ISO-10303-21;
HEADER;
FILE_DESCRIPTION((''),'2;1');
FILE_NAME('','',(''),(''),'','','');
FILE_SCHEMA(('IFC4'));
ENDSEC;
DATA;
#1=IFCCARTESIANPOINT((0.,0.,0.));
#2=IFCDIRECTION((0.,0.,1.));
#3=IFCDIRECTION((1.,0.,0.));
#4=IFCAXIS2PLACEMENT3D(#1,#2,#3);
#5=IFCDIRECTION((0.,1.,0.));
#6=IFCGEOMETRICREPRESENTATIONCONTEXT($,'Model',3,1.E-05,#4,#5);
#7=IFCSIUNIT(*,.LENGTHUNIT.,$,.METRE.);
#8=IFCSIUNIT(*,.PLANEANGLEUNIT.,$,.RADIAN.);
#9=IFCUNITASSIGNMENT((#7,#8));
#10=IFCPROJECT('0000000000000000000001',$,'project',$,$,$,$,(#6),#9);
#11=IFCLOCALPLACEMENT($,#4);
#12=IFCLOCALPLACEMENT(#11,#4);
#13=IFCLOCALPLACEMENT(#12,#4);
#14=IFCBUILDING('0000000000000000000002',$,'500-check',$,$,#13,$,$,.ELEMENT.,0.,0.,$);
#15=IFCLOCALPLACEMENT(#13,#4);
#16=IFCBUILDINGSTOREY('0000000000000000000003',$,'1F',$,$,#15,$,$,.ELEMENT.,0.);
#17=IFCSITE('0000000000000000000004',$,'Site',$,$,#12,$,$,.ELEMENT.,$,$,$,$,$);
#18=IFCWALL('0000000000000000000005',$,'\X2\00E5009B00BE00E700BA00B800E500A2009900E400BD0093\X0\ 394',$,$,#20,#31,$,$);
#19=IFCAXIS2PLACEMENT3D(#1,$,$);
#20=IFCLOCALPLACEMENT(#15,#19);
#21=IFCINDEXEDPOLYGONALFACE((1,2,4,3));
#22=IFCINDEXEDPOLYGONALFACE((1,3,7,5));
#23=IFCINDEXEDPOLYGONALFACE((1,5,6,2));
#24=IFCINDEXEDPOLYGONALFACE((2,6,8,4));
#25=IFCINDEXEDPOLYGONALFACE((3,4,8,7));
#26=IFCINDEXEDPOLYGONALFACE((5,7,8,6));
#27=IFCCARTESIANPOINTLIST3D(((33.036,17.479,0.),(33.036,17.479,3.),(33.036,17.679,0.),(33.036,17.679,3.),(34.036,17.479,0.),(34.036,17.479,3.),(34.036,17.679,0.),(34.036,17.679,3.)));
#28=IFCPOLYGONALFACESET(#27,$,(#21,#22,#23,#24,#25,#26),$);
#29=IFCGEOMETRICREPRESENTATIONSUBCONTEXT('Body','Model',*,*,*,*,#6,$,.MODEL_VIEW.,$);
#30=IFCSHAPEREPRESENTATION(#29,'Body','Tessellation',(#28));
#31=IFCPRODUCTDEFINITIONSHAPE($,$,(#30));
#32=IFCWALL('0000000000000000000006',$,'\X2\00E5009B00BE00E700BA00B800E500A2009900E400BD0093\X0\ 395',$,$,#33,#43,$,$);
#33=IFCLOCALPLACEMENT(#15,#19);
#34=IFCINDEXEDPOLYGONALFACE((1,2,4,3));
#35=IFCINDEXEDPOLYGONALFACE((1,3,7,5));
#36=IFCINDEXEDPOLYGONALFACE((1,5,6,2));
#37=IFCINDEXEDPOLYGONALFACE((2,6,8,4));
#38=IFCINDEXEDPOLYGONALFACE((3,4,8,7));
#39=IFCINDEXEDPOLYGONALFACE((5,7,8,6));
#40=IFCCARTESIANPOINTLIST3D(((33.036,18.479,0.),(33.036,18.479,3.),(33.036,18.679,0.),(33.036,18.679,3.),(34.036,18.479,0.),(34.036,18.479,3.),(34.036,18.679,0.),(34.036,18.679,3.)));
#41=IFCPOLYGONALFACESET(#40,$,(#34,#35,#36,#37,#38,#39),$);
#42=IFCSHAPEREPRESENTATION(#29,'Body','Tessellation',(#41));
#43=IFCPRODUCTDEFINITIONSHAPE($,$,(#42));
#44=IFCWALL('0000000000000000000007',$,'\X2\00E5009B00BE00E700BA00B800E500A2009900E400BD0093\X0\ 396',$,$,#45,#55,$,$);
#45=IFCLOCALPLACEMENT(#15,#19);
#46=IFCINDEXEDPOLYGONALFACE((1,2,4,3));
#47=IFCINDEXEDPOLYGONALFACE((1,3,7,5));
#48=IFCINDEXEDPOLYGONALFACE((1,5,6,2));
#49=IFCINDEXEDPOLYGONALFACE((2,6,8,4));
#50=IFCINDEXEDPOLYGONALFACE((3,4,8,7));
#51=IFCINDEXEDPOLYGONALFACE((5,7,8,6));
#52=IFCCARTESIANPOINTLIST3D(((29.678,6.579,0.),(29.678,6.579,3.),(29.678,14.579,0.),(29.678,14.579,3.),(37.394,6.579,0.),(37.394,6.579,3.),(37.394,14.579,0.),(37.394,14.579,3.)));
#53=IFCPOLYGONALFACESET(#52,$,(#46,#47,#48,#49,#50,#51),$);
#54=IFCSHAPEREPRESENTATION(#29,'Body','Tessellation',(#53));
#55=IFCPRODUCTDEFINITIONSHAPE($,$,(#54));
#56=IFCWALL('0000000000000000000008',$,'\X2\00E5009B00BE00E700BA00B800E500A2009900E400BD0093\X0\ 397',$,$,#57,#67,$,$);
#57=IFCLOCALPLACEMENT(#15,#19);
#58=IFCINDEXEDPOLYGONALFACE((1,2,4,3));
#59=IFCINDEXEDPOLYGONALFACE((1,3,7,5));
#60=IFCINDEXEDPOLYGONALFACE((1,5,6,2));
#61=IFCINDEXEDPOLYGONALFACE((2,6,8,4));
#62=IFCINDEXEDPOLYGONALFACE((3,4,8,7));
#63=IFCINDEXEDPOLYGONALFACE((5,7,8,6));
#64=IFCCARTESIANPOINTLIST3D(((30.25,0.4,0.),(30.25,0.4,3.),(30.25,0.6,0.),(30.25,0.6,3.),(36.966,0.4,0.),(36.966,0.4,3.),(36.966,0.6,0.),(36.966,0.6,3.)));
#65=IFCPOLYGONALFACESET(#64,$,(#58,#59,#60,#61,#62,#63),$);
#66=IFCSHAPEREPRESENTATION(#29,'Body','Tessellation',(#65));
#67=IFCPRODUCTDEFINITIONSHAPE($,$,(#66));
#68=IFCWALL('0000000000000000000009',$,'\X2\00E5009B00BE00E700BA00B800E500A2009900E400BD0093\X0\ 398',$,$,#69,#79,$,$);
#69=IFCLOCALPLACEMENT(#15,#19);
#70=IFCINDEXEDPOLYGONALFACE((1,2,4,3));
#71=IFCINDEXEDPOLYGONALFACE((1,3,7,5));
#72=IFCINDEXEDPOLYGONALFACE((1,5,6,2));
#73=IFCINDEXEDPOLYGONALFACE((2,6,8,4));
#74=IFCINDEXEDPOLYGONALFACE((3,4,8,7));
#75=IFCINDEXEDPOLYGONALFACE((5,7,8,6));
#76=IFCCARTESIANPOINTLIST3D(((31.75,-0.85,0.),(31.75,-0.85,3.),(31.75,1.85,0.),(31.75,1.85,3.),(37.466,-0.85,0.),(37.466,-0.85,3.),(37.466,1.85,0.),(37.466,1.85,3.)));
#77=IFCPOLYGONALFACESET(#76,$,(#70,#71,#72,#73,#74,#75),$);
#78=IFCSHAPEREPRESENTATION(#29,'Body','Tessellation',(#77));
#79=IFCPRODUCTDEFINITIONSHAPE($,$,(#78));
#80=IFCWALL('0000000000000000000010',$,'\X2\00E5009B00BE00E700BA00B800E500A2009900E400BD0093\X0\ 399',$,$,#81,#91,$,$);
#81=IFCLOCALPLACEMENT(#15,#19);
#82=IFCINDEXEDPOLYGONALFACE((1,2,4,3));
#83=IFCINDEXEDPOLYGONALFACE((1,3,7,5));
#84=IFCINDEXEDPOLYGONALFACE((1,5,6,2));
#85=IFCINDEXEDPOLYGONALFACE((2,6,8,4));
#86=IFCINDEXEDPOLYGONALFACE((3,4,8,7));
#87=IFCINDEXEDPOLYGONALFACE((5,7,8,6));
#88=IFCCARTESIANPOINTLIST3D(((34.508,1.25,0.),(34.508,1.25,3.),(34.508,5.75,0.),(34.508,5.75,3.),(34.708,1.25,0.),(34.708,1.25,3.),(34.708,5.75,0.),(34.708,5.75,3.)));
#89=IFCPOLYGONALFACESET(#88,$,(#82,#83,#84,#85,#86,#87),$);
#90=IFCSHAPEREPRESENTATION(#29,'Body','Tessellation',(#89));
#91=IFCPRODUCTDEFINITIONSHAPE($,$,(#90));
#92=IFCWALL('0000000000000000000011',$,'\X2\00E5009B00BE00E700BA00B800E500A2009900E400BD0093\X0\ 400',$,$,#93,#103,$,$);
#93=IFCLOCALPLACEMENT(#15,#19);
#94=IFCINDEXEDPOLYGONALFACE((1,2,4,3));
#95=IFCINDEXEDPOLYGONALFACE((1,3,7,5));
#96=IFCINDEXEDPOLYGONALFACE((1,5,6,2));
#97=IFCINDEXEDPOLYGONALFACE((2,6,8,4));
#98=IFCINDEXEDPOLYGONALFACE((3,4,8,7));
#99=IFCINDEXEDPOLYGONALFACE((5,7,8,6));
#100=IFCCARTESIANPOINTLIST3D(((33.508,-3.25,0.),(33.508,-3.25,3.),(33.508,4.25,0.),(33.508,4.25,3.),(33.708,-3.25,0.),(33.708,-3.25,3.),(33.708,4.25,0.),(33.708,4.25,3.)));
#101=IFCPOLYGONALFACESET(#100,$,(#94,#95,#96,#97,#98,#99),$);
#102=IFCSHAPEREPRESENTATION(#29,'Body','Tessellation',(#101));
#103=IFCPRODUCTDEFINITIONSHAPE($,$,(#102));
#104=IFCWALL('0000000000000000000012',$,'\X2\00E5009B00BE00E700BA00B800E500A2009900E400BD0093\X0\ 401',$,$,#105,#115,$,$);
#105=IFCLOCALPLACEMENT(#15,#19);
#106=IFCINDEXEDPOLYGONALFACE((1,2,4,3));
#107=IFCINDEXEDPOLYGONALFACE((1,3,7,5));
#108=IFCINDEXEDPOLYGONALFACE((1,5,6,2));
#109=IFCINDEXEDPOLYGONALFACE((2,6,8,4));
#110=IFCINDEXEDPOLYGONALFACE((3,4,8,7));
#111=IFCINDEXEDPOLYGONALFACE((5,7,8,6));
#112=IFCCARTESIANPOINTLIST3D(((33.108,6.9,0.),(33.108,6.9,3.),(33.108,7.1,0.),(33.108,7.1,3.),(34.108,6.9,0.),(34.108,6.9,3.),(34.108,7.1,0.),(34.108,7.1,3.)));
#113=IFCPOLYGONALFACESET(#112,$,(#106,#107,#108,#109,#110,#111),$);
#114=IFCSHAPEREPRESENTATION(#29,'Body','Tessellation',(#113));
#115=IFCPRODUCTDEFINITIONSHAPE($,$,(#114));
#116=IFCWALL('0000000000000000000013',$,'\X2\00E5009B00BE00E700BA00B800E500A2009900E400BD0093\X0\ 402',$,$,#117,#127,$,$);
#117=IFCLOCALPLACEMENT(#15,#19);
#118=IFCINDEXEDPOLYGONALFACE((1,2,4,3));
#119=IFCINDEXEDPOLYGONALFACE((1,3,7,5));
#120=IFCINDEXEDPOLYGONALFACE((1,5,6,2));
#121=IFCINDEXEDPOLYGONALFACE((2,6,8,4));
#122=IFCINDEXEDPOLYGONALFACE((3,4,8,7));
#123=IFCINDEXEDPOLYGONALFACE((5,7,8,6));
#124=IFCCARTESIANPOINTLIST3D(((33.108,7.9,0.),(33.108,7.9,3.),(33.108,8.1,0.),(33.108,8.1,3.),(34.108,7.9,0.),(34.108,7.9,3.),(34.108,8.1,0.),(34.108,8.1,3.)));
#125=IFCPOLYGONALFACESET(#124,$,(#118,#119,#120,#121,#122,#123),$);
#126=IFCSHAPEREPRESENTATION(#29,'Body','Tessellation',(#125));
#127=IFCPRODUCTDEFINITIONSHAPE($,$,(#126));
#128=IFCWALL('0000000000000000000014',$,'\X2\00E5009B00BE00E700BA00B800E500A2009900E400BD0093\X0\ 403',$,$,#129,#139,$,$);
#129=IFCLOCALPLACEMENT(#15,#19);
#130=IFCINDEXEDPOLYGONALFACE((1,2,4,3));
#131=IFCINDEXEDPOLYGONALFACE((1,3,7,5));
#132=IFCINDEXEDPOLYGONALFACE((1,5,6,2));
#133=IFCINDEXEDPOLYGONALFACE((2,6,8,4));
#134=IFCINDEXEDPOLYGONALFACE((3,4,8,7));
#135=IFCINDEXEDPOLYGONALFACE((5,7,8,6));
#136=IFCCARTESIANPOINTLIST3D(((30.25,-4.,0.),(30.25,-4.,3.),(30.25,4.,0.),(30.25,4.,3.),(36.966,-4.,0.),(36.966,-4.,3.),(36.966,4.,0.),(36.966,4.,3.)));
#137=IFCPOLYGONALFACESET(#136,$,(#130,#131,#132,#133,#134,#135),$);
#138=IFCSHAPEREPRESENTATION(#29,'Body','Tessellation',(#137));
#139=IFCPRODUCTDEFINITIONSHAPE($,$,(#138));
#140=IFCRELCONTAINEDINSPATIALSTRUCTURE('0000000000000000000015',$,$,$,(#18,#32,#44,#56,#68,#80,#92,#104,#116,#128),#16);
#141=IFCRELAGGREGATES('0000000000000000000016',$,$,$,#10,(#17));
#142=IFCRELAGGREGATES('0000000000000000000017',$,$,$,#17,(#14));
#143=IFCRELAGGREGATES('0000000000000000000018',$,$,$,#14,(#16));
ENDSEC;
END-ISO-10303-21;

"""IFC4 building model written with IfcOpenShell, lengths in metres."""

from ifc_helpers import new_model, si_unit, direction, frame, frame_2d, origin_with_axes, place, context, subcontext, project, spatial, rectangle, extrude, element, save


model = new_model("IFC4")

# Units and contexts
model_context = context("Model", 3, precision=1e-05, world=origin_with_axes(), true_north=direction((0.0, 1.0, 0.0)))
body_context = subcontext(model_context, "Body", "Model", "MODEL_VIEW")
ifc_project = project(units=[si_unit("LENGTHUNIT", "METRE"), si_unit("PLANEANGLEUNIT", "RADIAN")], contexts=[model_context])

# Site, building, storey
placement = place(None, origin_with_axes())
site_placement = place(placement, origin_with_axes())
site = spatial("IfcSite", under=ifc_project, at=site_placement, Name="Site", CompositionType="ELEMENT")
building_placement = place(site_placement, origin_with_axes())
building = spatial("IfcBuilding", under=site, at=building_placement, Name="500-check", CompositionType="ELEMENT", ElevationOfRefHeight=0.0, ElevationOfTerrain=0.0)
storey_placement = place(building_placement, origin_with_axes())
storey = spatial("IfcBuildingStorey", under=building, at=storey_placement, Name="1F", CompositionType="ELEMENT", Elevation=0.0)

# Walls
for number, where, z_axis, x_axis, name in (
    (1, (33.536, 17.579, 0.0), (0.0, 0.0, 1.0), (1.0, 0.0, 0.0), "å\u009b¾çº¸å¢\u0099ä½\u0093 394"),
    (2, (33.536, 18.579, 0.0), (0.0, 0.0, 1.0), (1.0, 0.0, 0.0), "å\u009b¾çº¸å¢\u0099ä½\u0093 395"),
):
    element("IfcWall", number, at=place(storey_placement, frame(where, z_axis=z_axis, x_axis=x_axis)), inside=storey, Name=name, context=body_context, shape_type="SweptSolid", body=[
        extrude(rectangle(XDim=1.0, YDim=0.2, at=frame_2d((0.0, 0.0), x_axis=(1.0, 0.0, 0.0))), frame((0.0, 0.0, 0.0), z_axis=(0.0, 0.0, 1.0)), (0.0, 0.0, 1.0), 3.0),
    ])
wall_1_placement = place(storey_placement, frame((33.536, 10.579, 0.0), z_axis=(0.0, 0.0, 1.0), x_axis=(1.0, 0.0, 0.0)))
element("IfcWall", 3, at=wall_1_placement, inside=storey, Name="å\u009b¾çº¸å¢\u0099ä½\u0093 396", context=body_context, shape_type="SweptSolid", body=[
    extrude(rectangle(XDim=7.716, YDim=8.0, at=frame_2d((0.0, 0.0), x_axis=(1.0, 0.0, 0.0))), frame((0.0, 0.0, 0.0), z_axis=(0.0, 0.0, 1.0)), (0.0, 0.0, 1.0), 3.0),
])
wall_2_placement = place(storey_placement, frame((33.608, 0.5, 0.0), z_axis=(0.0, 0.0, 1.0), x_axis=(1.0, 0.0, 0.0)))
element("IfcWall", 4, at=wall_2_placement, inside=storey, Name="å\u009b¾çº¸å¢\u0099ä½\u0093 397", context=body_context, shape_type="SweptSolid", body=[
    extrude(rectangle(XDim=6.716, YDim=0.2, at=frame_2d((0.0, 0.0), x_axis=(1.0, 0.0, 0.0))), frame((0.0, 0.0, 0.0), z_axis=(0.0, 0.0, 1.0)), (0.0, 0.0, 1.0), 3.0),
])
wall_3_placement = place(storey_placement, frame((34.608, 0.5, 0.0), z_axis=(0.0, 0.0, 1.0), x_axis=(1.0, 0.0, 0.0)))
element("IfcWall", 5, at=wall_3_placement, inside=storey, Name="å\u009b¾çº¸å¢\u0099ä½\u0093 398", context=body_context, shape_type="SweptSolid", body=[
    extrude(rectangle(XDim=5.716, YDim=2.7, at=frame_2d((0.0, 0.0), x_axis=(1.0, 0.0, 0.0))), frame((0.0, 0.0, 0.0), z_axis=(0.0, 0.0, 1.0)), (0.0, 0.0, 1.0), 3.0),
])
wall_4_placement = place(storey_placement, frame((34.608, 3.5, 0.0), z_axis=(0.0, 0.0, 1.0), x_axis=(0.0, 1.0, 0.0)))
element("IfcWall", 6, at=wall_4_placement, inside=storey, Name="å\u009b¾çº¸å¢\u0099ä½\u0093 399", context=body_context, shape_type="SweptSolid", body=[
    extrude(rectangle(XDim=4.5, YDim=0.2, at=frame_2d((0.0, 0.0), x_axis=(1.0, 0.0, 0.0))), frame((0.0, 0.0, 0.0), z_axis=(0.0, 0.0, 1.0)), (0.0, 0.0, 1.0), 3.0),
])
wall_5_placement = place(storey_placement, frame((33.608, 0.5, 0.0), z_axis=(0.0, 0.0, 1.0), x_axis=(0.0, 1.0, 0.0)))
element("IfcWall", 7, at=wall_5_placement, inside=storey, Name="å\u009b¾çº¸å¢\u0099ä½\u0093 400", context=body_context, shape_type="SweptSolid", body=[
    extrude(rectangle(XDim=7.5, YDim=0.2, at=frame_2d((0.0, 0.0), x_axis=(1.0, 0.0, 0.0))), frame((0.0, 0.0, 0.0), z_axis=(0.0, 0.0, 1.0)), (0.0, 0.0, 1.0), 3.0),
])
for number, where, z_axis, x_axis, name in (
    (8, (33.608, 7.0, 0.0), (0.0, 0.0, 1.0), (1.0, 0.0, 0.0), "å\u009b¾çº¸å¢\u0099ä½\u0093 401"),
    (9, (33.608, 8.0, 0.0), (0.0, 0.0, 1.0), (1.0, 0.0, 0.0), "å\u009b¾çº¸å¢\u0099ä½\u0093 402"),
):
    element("IfcWall", number, at=place(storey_placement, frame(where, z_axis=z_axis, x_axis=x_axis)), inside=storey, Name=name, context=body_context, shape_type="SweptSolid", body=[
        extrude(rectangle(XDim=1.0, YDim=0.2, at=frame_2d((0.0, 0.0), x_axis=(1.0, 0.0, 0.0))), frame((0.0, 0.0, 0.0), z_axis=(0.0, 0.0, 1.0)), (0.0, 0.0, 1.0), 3.0),
    ])
wall_6_placement = place(storey_placement, frame((33.608, 0.0, 0.0), z_axis=(0.0, 0.0, 1.0), x_axis=(1.0, 0.0, 0.0)))
element("IfcWall", 10, at=wall_6_placement, inside=storey, Name="å\u009b¾çº¸å¢\u0099ä½\u0093 403", context=body_context, shape_type="SweptSolid", body=[
    extrude(rectangle(XDim=6.716, YDim=8.0, at=frame_2d((0.0, 0.0), x_axis=(1.0, 0.0, 0.0))), frame((0.0, 0.0, 0.0), z_axis=(0.0, 0.0, 1.0)), (0.0, 0.0, 1.0), 3.0),
])

save(model, "model.ifc")
